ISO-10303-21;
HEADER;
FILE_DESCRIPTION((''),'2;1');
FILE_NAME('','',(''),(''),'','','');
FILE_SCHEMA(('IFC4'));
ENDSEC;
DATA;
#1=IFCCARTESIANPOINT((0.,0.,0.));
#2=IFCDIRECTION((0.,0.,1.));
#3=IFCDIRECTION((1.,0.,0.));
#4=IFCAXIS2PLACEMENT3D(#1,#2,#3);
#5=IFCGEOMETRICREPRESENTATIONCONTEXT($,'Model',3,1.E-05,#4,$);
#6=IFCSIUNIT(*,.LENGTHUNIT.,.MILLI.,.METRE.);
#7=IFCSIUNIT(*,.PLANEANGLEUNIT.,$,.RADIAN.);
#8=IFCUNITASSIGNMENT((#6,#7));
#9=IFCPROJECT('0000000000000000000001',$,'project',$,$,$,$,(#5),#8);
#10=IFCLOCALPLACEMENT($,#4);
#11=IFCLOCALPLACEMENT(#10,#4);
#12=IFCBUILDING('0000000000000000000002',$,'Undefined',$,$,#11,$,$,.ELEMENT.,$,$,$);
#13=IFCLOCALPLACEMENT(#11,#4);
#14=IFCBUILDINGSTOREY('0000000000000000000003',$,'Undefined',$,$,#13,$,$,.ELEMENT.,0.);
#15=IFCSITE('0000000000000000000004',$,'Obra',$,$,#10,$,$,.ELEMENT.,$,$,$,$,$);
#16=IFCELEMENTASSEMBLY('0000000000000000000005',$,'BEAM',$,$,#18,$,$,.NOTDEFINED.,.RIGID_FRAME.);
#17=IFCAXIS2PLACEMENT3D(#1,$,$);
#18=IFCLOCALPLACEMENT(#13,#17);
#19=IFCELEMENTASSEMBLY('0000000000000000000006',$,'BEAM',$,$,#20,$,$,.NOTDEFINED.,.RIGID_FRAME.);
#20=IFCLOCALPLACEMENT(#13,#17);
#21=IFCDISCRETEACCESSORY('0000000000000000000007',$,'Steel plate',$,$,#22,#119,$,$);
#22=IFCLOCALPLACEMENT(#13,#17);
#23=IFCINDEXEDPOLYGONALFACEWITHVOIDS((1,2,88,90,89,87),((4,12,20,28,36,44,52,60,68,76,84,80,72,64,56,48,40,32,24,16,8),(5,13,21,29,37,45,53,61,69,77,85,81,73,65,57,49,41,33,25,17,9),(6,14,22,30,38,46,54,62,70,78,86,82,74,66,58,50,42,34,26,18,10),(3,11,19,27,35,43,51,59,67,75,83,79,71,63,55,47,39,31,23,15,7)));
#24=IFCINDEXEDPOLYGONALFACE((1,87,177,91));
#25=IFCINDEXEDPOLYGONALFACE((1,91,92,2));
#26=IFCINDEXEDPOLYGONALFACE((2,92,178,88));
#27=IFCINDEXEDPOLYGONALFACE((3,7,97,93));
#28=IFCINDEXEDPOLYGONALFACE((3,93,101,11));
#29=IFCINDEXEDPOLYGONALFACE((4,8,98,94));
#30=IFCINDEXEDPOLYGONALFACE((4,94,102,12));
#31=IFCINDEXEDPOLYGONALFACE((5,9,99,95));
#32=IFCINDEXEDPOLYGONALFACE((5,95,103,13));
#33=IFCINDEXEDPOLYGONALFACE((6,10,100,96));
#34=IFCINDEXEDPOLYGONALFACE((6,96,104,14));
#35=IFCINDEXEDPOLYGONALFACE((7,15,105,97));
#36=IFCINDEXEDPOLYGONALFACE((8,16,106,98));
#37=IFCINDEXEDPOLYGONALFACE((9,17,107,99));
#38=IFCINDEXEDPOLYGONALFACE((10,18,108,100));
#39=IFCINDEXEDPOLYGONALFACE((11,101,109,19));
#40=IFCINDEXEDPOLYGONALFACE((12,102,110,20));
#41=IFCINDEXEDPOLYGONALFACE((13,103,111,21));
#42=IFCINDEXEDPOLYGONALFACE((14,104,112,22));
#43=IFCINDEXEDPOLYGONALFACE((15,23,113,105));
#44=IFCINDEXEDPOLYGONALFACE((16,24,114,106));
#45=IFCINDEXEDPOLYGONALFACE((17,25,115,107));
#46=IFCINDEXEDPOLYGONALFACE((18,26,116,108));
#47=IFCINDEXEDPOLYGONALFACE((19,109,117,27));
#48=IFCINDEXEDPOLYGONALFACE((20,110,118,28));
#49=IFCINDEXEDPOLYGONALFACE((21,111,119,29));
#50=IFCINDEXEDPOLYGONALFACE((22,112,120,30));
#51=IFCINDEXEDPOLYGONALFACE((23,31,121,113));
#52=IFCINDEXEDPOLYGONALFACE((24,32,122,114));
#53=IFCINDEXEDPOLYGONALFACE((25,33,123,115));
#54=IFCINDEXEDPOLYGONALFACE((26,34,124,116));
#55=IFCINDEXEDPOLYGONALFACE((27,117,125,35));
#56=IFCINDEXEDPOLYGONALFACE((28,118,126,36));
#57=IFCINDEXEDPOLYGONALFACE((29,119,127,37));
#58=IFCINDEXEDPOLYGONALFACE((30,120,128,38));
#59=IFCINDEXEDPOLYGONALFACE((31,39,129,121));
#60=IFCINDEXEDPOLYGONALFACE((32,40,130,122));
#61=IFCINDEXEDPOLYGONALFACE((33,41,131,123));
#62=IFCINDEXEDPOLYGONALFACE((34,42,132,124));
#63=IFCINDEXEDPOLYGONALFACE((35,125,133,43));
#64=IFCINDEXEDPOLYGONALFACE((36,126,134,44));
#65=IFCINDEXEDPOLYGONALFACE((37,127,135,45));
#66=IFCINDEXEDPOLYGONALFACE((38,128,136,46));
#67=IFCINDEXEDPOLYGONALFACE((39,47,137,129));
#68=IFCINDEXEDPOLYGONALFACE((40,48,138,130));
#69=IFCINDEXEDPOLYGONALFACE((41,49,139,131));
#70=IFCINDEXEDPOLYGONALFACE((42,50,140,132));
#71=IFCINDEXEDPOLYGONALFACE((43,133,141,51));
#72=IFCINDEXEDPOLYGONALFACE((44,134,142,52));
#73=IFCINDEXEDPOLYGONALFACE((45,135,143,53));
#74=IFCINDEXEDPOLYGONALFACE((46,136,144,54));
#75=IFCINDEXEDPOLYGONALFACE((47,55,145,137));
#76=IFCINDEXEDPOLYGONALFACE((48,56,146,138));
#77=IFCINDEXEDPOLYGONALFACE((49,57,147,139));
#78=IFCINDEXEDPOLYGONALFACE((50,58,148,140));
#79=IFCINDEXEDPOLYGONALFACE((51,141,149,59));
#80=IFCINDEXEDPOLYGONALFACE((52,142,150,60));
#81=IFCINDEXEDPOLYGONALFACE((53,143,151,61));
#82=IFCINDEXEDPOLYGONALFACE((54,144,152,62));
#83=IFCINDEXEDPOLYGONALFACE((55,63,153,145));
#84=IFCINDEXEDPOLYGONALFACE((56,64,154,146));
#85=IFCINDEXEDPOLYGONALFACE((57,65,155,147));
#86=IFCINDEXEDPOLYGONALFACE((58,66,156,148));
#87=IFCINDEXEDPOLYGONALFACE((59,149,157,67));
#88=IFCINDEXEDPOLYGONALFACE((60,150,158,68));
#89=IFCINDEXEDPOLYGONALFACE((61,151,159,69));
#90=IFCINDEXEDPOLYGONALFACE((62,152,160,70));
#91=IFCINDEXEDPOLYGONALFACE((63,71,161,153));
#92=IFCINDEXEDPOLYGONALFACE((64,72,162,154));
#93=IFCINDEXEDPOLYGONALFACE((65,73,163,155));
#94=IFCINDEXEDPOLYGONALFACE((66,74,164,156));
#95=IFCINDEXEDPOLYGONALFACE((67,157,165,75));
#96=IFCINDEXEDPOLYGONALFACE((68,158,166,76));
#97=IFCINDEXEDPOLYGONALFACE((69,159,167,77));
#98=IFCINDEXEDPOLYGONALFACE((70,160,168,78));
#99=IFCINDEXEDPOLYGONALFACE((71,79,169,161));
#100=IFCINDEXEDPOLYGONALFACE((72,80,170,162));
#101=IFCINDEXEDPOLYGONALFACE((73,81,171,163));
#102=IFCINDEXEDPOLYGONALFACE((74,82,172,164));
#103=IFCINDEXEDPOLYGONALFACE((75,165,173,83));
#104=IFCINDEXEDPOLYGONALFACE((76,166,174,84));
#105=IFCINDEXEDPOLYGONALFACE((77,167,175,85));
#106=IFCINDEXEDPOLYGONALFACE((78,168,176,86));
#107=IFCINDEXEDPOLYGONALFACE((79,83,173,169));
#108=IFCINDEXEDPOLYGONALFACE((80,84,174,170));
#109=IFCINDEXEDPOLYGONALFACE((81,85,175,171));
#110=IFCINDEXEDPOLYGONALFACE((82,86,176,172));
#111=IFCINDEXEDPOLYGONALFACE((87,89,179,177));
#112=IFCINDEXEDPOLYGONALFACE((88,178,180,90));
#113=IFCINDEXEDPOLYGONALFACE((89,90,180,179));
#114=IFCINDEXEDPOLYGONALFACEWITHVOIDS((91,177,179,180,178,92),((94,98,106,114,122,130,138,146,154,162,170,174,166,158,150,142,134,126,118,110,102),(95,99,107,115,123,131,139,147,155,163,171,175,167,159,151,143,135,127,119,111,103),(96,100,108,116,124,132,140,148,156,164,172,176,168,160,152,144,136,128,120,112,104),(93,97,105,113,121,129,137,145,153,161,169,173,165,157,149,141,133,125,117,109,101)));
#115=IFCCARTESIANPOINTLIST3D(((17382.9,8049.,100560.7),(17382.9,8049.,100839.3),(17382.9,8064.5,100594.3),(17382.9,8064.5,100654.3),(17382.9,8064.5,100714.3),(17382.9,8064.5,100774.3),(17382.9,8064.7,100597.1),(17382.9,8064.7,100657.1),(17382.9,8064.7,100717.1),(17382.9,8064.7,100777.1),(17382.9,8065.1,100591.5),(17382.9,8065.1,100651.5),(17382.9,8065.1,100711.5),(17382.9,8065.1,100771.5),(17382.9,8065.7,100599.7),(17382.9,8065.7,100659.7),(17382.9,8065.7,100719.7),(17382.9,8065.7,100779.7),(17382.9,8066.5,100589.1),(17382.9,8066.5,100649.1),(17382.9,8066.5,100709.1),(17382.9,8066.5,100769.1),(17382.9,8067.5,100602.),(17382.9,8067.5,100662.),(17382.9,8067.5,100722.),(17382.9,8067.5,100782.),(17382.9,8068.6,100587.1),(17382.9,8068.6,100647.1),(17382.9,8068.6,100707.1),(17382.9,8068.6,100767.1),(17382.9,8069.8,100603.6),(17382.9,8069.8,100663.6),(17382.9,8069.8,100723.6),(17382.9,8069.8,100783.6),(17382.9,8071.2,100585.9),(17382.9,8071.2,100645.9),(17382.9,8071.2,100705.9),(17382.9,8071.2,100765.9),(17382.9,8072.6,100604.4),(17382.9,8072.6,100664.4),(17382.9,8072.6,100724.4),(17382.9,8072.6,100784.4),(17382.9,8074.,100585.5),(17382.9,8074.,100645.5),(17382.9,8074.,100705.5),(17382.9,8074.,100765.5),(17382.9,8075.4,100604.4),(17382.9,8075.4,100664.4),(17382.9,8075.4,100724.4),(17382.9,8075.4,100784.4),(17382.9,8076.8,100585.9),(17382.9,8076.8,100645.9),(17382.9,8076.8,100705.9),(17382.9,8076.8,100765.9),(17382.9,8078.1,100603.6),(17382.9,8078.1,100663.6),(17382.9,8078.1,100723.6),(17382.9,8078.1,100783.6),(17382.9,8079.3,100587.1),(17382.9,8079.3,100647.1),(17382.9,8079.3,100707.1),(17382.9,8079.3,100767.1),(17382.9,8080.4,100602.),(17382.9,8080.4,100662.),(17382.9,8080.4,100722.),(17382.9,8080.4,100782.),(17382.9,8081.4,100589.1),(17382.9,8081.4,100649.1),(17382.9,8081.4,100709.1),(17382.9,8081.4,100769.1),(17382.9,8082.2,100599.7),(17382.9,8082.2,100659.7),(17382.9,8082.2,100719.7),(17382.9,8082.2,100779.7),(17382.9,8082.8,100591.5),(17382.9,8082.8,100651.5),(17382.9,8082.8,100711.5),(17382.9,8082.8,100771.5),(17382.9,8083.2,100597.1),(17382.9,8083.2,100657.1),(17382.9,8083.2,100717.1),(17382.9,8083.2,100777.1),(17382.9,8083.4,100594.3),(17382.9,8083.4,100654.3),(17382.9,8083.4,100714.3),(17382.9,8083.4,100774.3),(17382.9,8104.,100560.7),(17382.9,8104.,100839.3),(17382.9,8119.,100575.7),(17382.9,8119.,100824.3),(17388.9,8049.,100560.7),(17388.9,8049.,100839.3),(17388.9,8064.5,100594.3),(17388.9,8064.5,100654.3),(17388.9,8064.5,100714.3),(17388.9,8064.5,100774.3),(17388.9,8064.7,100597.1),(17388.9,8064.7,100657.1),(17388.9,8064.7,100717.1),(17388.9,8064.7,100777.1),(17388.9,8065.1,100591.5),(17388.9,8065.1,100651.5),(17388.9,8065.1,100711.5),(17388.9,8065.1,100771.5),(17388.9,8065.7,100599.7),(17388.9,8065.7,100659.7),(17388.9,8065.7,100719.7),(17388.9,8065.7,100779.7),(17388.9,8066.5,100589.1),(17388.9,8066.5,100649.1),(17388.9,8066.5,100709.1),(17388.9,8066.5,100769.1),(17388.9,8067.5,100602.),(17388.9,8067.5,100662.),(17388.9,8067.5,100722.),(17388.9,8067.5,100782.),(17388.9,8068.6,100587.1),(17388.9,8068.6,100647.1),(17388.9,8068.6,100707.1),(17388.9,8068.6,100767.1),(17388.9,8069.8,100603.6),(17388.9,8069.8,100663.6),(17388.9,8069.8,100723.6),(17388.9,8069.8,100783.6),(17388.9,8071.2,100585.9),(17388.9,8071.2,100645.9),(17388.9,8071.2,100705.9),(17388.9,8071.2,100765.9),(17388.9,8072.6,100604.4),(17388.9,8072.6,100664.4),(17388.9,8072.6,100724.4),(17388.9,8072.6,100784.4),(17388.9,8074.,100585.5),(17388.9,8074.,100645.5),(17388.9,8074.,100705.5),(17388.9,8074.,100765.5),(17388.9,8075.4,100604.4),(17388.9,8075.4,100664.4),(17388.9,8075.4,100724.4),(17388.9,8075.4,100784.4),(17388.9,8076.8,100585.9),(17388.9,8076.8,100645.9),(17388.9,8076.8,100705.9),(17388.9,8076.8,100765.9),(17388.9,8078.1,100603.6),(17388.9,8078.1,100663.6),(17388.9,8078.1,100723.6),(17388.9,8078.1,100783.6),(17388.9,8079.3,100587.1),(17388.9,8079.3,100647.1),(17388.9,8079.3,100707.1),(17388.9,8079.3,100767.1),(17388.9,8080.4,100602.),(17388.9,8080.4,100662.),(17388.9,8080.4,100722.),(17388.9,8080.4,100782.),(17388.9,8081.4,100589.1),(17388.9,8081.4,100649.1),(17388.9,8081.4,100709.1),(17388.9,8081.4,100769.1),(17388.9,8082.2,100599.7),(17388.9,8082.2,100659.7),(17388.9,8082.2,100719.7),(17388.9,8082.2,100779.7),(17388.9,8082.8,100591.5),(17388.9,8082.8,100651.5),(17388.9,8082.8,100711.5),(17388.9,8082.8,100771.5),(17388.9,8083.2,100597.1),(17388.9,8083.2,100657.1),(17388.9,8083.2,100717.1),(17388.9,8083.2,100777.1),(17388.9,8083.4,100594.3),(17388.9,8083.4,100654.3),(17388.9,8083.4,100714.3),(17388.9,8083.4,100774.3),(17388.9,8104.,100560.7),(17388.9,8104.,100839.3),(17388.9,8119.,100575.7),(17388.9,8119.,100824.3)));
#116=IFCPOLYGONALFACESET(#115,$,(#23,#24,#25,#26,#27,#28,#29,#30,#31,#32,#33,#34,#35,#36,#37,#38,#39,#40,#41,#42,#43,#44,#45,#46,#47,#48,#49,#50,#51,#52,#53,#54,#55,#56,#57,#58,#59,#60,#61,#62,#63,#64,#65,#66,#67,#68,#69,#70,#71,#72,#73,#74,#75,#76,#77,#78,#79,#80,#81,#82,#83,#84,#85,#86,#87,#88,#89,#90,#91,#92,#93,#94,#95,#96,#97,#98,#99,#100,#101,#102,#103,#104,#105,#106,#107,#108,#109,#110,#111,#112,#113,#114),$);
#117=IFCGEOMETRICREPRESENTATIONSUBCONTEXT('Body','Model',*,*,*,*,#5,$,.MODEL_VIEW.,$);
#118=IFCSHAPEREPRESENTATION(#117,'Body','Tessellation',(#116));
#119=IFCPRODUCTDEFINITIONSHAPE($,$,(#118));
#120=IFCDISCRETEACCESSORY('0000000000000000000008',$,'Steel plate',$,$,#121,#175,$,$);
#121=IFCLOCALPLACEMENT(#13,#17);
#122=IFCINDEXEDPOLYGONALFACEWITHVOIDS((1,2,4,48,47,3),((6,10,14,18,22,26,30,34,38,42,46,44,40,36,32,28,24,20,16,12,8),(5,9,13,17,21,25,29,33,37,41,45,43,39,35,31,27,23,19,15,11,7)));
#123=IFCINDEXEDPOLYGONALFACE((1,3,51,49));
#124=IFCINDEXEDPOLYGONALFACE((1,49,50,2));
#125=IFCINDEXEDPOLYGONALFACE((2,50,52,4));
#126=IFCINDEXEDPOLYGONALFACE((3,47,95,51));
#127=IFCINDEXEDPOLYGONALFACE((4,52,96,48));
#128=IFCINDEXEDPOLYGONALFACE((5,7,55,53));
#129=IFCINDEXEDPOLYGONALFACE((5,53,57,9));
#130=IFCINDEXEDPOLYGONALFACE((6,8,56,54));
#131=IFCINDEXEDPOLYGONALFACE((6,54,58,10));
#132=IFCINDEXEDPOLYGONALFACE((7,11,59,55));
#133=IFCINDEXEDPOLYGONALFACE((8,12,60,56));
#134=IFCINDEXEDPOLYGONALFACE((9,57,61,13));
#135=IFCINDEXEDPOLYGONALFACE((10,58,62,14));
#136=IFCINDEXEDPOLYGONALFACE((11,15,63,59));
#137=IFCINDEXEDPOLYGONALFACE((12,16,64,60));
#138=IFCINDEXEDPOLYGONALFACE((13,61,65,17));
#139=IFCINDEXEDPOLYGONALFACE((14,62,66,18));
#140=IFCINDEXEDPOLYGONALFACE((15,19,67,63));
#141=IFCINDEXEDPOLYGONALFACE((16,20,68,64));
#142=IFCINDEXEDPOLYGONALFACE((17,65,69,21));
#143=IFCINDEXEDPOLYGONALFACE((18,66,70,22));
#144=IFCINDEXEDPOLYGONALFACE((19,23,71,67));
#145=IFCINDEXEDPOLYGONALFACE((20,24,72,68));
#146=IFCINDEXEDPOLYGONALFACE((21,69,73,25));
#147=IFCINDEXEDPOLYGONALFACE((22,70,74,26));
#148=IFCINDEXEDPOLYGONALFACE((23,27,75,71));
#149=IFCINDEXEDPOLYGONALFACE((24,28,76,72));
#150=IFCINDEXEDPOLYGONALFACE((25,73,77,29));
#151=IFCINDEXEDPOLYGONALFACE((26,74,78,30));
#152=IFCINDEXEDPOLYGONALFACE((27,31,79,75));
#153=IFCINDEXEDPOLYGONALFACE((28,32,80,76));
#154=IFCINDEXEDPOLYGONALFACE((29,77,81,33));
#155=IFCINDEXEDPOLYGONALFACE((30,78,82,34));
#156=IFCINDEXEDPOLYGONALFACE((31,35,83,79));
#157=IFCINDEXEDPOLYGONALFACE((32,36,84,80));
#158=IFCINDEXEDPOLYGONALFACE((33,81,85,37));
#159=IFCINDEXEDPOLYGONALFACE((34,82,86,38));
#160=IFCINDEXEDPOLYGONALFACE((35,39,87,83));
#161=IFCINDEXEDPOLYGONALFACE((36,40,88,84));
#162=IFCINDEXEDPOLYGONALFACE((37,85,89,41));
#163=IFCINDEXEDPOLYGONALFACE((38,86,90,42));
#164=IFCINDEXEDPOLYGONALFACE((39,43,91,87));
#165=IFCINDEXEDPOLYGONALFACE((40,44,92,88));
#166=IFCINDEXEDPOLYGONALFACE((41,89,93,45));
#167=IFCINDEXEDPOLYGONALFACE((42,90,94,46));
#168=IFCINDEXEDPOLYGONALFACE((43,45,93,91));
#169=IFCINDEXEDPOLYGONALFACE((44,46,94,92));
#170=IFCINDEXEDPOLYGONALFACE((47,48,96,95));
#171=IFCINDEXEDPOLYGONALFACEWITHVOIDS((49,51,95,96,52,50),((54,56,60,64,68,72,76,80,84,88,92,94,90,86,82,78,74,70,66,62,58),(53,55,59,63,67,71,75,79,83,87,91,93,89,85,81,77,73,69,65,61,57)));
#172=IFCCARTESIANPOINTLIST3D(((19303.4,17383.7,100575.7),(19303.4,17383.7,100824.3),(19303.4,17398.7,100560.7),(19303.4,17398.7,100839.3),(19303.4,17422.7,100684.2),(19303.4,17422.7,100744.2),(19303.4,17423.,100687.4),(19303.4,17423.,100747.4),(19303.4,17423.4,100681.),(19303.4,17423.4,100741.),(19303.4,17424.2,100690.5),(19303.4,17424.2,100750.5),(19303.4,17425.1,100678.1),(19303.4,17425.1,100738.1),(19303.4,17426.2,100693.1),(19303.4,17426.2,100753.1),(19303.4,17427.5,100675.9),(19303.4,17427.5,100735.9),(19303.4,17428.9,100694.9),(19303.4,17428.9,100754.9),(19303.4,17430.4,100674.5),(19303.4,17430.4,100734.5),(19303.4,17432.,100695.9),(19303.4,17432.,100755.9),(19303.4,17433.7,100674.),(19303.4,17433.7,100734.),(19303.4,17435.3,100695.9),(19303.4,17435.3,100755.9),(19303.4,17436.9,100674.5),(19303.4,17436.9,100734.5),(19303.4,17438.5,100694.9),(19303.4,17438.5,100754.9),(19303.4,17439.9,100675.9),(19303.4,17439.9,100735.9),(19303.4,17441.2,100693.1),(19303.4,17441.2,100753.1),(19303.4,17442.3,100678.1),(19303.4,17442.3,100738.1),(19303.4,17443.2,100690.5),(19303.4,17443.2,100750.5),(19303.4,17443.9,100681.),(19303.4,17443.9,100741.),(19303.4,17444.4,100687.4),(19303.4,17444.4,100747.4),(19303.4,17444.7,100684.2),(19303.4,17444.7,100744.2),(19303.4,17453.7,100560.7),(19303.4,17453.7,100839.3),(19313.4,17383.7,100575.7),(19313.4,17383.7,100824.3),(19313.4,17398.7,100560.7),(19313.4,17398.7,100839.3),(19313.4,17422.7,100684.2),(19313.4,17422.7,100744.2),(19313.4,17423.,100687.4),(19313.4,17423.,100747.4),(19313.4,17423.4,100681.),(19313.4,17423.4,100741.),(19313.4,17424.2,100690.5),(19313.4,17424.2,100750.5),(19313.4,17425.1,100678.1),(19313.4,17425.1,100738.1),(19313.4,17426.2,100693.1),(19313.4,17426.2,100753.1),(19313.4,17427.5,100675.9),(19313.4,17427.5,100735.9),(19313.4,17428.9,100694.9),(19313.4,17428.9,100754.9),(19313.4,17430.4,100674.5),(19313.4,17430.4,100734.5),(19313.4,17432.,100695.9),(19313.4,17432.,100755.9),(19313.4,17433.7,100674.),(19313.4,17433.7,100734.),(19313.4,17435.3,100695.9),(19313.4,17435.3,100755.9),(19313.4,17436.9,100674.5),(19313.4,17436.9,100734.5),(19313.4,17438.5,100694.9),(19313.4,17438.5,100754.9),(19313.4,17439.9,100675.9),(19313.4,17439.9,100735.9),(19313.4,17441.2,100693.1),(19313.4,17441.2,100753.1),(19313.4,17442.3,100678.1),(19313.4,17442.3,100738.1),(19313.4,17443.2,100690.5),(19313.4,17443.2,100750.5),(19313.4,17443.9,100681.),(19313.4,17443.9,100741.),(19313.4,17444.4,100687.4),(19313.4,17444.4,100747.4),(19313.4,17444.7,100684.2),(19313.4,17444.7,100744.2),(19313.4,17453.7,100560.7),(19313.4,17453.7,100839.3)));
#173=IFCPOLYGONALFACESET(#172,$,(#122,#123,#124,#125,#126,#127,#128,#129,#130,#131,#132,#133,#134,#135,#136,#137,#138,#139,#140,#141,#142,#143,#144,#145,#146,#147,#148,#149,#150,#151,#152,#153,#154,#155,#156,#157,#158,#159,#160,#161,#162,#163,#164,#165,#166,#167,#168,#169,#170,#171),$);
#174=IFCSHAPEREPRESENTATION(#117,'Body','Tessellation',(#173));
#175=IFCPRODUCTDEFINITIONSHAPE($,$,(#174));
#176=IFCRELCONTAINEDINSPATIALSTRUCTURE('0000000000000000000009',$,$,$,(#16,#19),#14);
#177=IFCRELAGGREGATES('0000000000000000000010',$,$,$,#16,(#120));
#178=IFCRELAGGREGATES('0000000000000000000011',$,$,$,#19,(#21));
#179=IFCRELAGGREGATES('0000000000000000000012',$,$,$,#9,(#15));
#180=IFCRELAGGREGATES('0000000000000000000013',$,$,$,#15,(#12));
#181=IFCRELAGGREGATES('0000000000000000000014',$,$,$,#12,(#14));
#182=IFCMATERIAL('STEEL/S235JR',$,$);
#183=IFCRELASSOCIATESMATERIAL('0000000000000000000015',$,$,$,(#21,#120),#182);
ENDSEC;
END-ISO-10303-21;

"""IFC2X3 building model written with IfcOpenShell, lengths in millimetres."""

from ifc_helpers import new_model, si_unit, frame, origin_with_axes, origin_2d_with_axis, place, context, subcontext, project, spatial, polyline, circle, outline, extrude, source, transform, mapped, material, element, aggregate, save


model = new_model("IFC2X3")

# Units and contexts
model_context = context("Model", 3, precision=1e-05, world=origin_with_axes())
body_context = subcontext(model_context, "Body", "Model", "MODEL_VIEW")
ifc_project = project(units=[si_unit("LENGTHUNIT", "METRE", prefix="MILLI"), si_unit("PLANEANGLEUNIT", "RADIAN")], contexts=[model_context])

# Site, building, storey
site_placement = place(None, origin_with_axes())
site = spatial("IfcSite", under=ifc_project, at=site_placement, Name="Obra", CompositionType="ELEMENT")
building_placement = place(site_placement, origin_with_axes())
building = spatial("IfcBuilding", under=site, at=building_placement, Name="Undefined", CompositionType="ELEMENT")
storey_placement = place(building_placement, origin_with_axes())
storey = spatial("IfcBuildingStorey", under=building, at=storey_placement, Name="Undefined", CompositionType="ELEMENT", Elevation=0.0)

# Element assemblies, discrete accessory, opening
assembly_1_placement = place(storey_placement, origin_with_axes())
assembly_1 = element("IfcElementAssembly", 1, at=assembly_1_placement, inside=storey, Name="BEAM", AssemblyPlace="NOTDEFINED", PredefinedType="RIGID_FRAME")
ifc_material_1 = material(Name="STEEL/S235JR")
shared_shape_1 = source(origin_with_axes(), body_context, "Body", "SweptSolid", [
    extrude(circle(Radius=9.5, at=origin_2d_with_axis()), frame((0.0, -9.8, 0.0), z_axis=(0.0, 1.0, 0.0), x_axis=(1.0, 0.0, 0.0)), (0.0, 0.0, 1.0), 6.2),
])
assembly_2_placement = place(storey_placement, origin_with_axes())
assembly_2 = element("IfcElementAssembly", 2, at=assembly_2_placement, inside=storey, Name="BEAM", AssemblyPlace="NOTDEFINED", PredefinedType="RIGID_FRAME")
discrete_accessory_1_placement = place(assembly_2_placement, frame((17385.9, 8049.0, 100560.7), z_axis=(1.0, 0.0, 0.0), x_axis=(0.0, 1.0, 0.0)))
discrete_accessory_1 = element("IfcDiscreteAccessory", 3, at=discrete_accessory_1_placement, material=ifc_material_1, Name="Steel plate", context=body_context, shape_type="SweptSolid", body=[
    extrude(outline(polyline([(0.0, 0.0), (55.0, 0.0), (70.0, 15.0), (70.0, 263.6), (55.0, 278.6), (0.0, 278.6), (0.0, 0.0)])), frame((0.0, 0.0, -3.0), z_axis=(0.0, 0.0, 1.0), x_axis=(1.0, 0.0, 0.0)), (0.0, 0.0, 1.0), 6.0),
])
opening_1_placement = place(assembly_2_placement, frame((17392.7, 8109.0, 100850.0), z_axis=(0.0, -1.0, 0.0), x_axis=(0.0, 0.0, -1.0)))
element("IfcOpeningElement", 4, at=opening_1_placement, cuts=discrete_accessory_1, ObjectType="Opening", context=body_context, shape_type="MappedRepresentation", body=[
    mapped(shared_shape_1, transform((75.0, 0.0, 35.0))),
    mapped(shared_shape_1, transform((135.0, 0.0, 35.0))),
    mapped(shared_shape_1, transform((195.0, 0.0, 35.0))),
    mapped(shared_shape_1, transform((255.0, 0.0, 35.0))),
])

# Discrete accessory, opening
discrete_accessory_2_placement = place(assembly_1_placement, frame((19308.4, 17453.7, 100560.7), z_axis=(-1.0, 0.0, 0.0), x_axis=(0.0, -1.0, 0.0)))
discrete_accessory_2 = element("IfcDiscreteAccessory", 5, at=discrete_accessory_2_placement, material=ifc_material_1, Name="Steel plate", context=body_context, shape_type="SweptSolid", body=[
    extrude(outline(polyline([(0.0, 0.0), (55.0, 0.0), (70.0, 15.0), (70.0, 263.6), (55.0, 278.6), (0.0, 278.6), (0.0, 0.0)])), frame((0.0, 0.0, -5.0), z_axis=(0.0, 0.0, 1.0), x_axis=(1.0, 0.0, 0.0)), (0.0, 0.0, 1.0), 10.0),
])
shared_shape_2 = source(origin_with_axes(), body_context, "Body", "SweptSolid", [
    extrude(circle(Radius=11.0, at=origin_2d_with_axis()), frame((0.0, -13.4, 0.0), z_axis=(0.0, 1.0, 0.0), x_axis=(1.0, 0.0, 0.0)), (0.0, 0.0, 1.0), 10.2),
])
opening_2_placement = place(assembly_1_placement, frame((19300.1, 17393.7, 100850.0), z_axis=(0.0, 1.0, 0.0), x_axis=(0.0, 0.0, -1.0)))
element("IfcOpeningElement", 6, at=opening_2_placement, cuts=discrete_accessory_2, ObjectType="Opening", context=body_context, shape_type="MappedRepresentation", body=[
    mapped(shared_shape_2, transform((105.0, 0.0, 40.0))),
    mapped(shared_shape_2, transform((165.0, 0.0, 40.0))),
])
aggregate(assembly_1, [discrete_accessory_2])
aggregate(assembly_2, [discrete_accessory_1])

save(model, "model.ifc")
